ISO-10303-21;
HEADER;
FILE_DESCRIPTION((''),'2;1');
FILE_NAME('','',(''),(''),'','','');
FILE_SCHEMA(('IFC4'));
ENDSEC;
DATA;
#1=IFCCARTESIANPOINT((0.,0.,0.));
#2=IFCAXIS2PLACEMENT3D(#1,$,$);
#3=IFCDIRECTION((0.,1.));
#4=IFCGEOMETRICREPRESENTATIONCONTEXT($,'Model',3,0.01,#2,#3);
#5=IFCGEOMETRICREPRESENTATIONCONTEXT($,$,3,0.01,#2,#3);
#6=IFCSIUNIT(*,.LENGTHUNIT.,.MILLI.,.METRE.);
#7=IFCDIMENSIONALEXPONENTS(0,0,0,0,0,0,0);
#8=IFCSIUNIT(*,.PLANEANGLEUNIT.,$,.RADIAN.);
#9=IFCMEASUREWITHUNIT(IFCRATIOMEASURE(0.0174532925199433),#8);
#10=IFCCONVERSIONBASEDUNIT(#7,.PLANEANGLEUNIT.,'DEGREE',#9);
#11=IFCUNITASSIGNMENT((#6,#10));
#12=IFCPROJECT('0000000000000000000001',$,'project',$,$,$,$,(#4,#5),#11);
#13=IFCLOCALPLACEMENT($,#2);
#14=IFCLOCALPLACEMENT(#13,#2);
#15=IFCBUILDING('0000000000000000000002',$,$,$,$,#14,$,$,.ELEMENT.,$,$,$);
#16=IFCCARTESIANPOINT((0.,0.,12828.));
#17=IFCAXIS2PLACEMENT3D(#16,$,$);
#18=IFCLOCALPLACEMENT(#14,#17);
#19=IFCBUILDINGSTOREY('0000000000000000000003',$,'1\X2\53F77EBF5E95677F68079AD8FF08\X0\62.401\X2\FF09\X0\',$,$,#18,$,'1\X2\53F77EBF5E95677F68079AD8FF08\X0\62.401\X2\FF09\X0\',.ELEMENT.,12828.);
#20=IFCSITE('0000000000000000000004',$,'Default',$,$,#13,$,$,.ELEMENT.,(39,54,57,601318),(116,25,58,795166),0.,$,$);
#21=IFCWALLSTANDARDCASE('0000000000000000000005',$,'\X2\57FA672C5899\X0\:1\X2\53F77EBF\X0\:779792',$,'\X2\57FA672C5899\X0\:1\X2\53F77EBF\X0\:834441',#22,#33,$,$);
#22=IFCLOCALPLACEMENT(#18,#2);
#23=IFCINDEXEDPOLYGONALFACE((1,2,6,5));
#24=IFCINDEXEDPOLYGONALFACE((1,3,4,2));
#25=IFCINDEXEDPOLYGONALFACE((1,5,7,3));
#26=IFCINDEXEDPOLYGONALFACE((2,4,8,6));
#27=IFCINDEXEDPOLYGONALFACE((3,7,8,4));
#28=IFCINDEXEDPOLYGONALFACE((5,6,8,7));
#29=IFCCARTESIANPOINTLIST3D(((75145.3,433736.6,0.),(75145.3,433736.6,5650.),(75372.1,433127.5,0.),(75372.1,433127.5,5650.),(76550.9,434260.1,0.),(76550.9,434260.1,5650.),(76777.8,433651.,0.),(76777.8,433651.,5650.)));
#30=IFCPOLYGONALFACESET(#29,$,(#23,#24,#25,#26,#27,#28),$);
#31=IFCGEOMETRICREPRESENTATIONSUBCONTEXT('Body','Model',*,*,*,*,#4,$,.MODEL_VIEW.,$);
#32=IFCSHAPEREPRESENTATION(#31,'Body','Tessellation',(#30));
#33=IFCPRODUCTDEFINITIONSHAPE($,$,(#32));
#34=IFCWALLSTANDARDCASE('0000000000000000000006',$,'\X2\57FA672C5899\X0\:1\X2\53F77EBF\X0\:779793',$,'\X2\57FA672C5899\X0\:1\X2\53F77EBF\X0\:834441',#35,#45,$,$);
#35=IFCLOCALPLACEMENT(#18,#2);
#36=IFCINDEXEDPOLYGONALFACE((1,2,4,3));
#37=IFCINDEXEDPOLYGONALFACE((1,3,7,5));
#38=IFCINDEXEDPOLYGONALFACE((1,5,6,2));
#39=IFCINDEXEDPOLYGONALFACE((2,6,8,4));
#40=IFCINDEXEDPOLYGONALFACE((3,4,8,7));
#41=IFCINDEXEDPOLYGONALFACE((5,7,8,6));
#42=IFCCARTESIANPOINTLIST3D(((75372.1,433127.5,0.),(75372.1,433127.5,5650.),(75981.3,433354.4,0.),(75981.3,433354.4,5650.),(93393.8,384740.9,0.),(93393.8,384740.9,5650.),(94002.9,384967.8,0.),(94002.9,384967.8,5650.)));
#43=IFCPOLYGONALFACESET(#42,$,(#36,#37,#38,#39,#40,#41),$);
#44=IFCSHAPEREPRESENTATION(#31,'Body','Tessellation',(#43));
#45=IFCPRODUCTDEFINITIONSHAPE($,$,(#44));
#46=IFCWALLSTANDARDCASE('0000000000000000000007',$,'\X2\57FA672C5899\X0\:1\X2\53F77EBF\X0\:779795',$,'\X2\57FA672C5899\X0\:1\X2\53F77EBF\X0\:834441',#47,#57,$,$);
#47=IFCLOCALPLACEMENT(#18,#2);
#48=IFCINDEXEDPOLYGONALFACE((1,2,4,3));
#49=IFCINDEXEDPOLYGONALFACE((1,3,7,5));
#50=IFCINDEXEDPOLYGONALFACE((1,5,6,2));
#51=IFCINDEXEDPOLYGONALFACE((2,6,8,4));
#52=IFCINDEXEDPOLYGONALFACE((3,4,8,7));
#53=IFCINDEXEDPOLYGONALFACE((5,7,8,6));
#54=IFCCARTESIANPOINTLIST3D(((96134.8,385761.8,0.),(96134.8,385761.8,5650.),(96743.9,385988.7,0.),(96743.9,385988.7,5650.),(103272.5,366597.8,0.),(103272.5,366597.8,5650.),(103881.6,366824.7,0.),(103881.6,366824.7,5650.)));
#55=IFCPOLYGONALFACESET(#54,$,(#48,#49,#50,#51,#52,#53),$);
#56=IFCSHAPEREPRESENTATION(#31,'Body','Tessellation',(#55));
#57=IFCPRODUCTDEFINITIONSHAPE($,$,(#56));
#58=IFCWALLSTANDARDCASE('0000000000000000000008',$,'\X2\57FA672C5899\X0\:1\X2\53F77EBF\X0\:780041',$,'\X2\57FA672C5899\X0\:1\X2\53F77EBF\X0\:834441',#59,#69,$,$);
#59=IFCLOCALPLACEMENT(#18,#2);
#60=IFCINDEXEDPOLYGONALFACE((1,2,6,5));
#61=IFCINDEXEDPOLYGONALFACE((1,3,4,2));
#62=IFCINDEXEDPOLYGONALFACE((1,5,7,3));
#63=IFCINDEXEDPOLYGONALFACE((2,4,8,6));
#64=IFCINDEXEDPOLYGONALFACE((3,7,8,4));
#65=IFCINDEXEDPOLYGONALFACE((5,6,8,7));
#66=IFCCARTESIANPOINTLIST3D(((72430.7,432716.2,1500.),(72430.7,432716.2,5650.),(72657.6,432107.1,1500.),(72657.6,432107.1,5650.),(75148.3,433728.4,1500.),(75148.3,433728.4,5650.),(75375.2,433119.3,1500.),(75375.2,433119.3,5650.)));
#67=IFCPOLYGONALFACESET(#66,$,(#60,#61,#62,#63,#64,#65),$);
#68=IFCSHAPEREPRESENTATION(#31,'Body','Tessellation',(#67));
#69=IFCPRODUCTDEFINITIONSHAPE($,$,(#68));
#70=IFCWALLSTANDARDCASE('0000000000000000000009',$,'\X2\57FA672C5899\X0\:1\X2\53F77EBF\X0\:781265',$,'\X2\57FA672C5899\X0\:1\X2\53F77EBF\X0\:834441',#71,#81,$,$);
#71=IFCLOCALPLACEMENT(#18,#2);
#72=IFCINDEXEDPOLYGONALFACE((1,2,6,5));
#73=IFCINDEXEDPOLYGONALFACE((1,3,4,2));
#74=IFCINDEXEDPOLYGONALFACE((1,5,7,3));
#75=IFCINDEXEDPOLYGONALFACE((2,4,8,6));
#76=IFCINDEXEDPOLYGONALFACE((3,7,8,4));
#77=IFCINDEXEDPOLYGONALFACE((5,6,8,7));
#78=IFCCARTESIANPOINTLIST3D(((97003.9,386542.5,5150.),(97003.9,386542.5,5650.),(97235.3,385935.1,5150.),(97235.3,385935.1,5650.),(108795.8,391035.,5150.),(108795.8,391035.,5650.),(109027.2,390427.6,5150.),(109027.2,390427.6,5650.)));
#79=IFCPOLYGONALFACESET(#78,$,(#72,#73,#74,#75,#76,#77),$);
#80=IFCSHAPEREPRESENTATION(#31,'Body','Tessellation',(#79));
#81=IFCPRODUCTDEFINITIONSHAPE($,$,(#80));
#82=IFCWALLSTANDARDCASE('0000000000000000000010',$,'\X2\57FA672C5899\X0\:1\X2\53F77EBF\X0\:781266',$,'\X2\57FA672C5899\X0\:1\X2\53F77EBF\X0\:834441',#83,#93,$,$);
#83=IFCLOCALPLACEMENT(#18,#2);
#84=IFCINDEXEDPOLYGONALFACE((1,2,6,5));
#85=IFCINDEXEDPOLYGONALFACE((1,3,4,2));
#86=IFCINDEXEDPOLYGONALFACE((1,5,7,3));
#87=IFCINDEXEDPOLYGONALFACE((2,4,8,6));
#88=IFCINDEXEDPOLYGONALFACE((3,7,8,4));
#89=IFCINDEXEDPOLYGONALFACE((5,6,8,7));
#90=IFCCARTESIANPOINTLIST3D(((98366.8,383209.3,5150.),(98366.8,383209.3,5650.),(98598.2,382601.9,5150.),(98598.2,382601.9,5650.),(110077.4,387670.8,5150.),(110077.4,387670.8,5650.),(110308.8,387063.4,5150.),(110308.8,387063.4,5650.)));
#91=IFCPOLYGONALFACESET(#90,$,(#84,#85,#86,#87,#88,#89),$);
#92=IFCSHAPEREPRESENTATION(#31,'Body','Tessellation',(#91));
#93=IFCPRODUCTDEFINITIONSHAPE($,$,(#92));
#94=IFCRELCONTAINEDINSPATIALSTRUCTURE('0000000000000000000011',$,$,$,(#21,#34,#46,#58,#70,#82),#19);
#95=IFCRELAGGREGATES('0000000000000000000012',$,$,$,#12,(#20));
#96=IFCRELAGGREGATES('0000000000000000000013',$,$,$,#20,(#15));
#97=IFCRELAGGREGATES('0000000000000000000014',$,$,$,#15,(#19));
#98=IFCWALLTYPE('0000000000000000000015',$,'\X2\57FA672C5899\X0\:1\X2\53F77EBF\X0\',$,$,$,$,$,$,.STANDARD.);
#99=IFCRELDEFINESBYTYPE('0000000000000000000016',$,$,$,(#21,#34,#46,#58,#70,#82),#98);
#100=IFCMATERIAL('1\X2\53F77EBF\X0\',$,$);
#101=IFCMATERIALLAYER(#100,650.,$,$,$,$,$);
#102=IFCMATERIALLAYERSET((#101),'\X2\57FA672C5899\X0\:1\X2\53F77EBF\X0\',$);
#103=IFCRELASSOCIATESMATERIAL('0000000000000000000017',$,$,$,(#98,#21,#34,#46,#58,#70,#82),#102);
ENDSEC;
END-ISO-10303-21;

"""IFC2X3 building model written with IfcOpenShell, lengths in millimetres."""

from ifc_helpers import new_model, entity, si_unit, converted_unit, direction, frame, frame_2d, origin, place, context, subcontext, project, spatial, polyline, rectangle, extrude, clip, bounded_halfspace, material, layer, layer_set, layer_usage, type_object, element, save


model = new_model("IFC2X3")

# Units and contexts
model_context = context("Model", 3, precision=0.01, world=origin(), true_north=direction((0.0, 1.0)))
context_of_model = context(None, 3, precision=0.01, world=origin(), true_north=direction((0.0, 1.0)))
body_context = subcontext(model_context, "Body", "Model", "MODEL_VIEW")
ifc_project = project(units=[si_unit("LENGTHUNIT", "METRE", prefix="MILLI"), converted_unit("PLANEANGLEUNIT", "DEGREE", entity("IfcRatioMeasure", 0.0174532925199433), si_unit("PLANEANGLEUNIT", "RADIAN"), dimensions=[0, 0, 0, 0, 0, 0, 0])], contexts=[model_context, context_of_model])

# Site, building, storey
site_placement = place(None, origin())
site = spatial("IfcSite", under=ifc_project, at=site_placement, Name="Default", CompositionType="ELEMENT", RefLatitude=(39, 54, 57, 601318), RefLongitude=(116, 25, 58, 795166), RefElevation=0.0)
building_placement = place(site_placement, origin())
building = spatial("IfcBuilding", under=site, at=building_placement, CompositionType="ELEMENT")
storey_placement = place(building_placement, frame((0.0, 0.0, 12828.0)))
storey = spatial("IfcBuildingStorey", under=building, at=storey_placement, Name="1号线底板标高（62.401）", LongName="1号线底板标高（62.401）", CompositionType="ELEMENT", Elevation=12828.0)

# Walls
ifc_material_1 = material(Name="1号线")
ifc_layer = layer(ifc_material_1, 650.0)
ifc_layer_set = layer_set([ifc_layer], Name="基本墙:1号线")
ifc_layer_usage_1 = layer_usage(ifc_layer_set, "AXIS2", "NEGATIVE", 325.0)
wall_type = type_object("IfcWallType", Name="基本墙:1号线", PredefinedType="STANDARD", material=ifc_layer_set)
wall_1_placement = place(storey_placement, frame((76664.4, 433955.6, 0.0), z_axis=(0.0, 0.0, 1.0), x_axis=(-0.937112, -0.349028, 0.0)))
element("IfcWallStandardCase", 1, at=wall_1_placement, inside=storey, type_object=wall_type, material=ifc_layer_usage_1, Name="基本墙:1号线:779792", ObjectType="基本墙:1号线:834441", context=body_context, shape_type="Clipping", body=[
    clip(extrude(rectangle(XDim=1500.0, YDim=650.0, at=frame_2d((750.0, 0.0), x_axis=(-1.0, 0.0))), origin(), (0.0, 0.0, 1.0), 5650.0), bounded_halfspace(frame((0.0, -325.0, 5650.0), z_axis=(0.0, 0.0, -1.0), x_axis=(-1.0, 0.0, 0.0)), True, frame((0.0, -325.0, 5650.0)), polyline([(0.0, 0.0), (650.0, 0.0), (1500.0, 0.0), (1500.0, 8.7), (1500.0, 650.0), (850.0, 650.0), (650.0, 650.0), (0.0, 650.0), (0.0, 0.0)]))),
])
ifc_layer_usage_2 = layer_usage(ifc_layer_set, "AXIS2", "NEGATIVE", 325.0)
wall_2_placement = place(storey_placement, frame((75676.7, 433240.9, 0.0), z_axis=(0.0, 0.0, 1.0), x_axis=(0.349028, -0.937112, 0.0)))
element("IfcWallStandardCase", 2, at=wall_2_placement, inside=storey, type_object=wall_type, material=ifc_layer_usage_2, Name="基本墙:1号线:779793", ObjectType="基本墙:1号线:834441", context=body_context, shape_type="Clipping", body=[
    clip(extrude(rectangle(XDim=51633.7, YDim=650.0, at=frame_2d((25816.9, 0.0), x_axis=(-1.0, 0.0))), origin(), (0.0, 0.0, 1.0), 5650.0), bounded_halfspace(frame((0.0, -325.0, 5650.0), z_axis=(0.0, 0.0, -1.0), x_axis=(0.0, 1.0, 0.0)), True, frame((0.0, -325.0, 5650.0)), polyline([(0.0, 0.0), (8.7, 0.0), (50986.2, 0.0), (50984.3, 650.0), (50875.9, 650.0), (208.7, 650.0), (0.0, 650.0), (0.0, 0.0)]))),
])
ifc_layer_usage_3 = layer_usage(ifc_layer_set, "AXIS2", "NEGATIVE", 325.0)
wall_3_placement = place(storey_placement, frame((96439.4, 385875.2, 0.0), z_axis=(0.0, 0.0, 1.0), x_axis=(0.349028, -0.937112, 0.0)))
element("IfcWallStandardCase", 3, at=wall_3_placement, inside=storey, type_object=wall_type, material=ifc_layer_usage_3, Name="基本墙:1号线:779795", ObjectType="基本墙:1号线:834441", context=body_context, shape_type="SweptSolid", body=[
    extrude(rectangle(XDim=20450.0, YDim=650.0, at=frame_2d((10225.0, 0.0), x_axis=(-1.0, 0.0))), origin(), (0.0, 0.0, 1.0), 5650.0),
])
ifc_layer_usage_4 = layer_usage(ifc_layer_set, "AXIS2", "NEGATIVE", 325.0)
wall_4_placement = place(storey_placement, frame((72544.1, 432411.7, 1500.0), z_axis=(0.0, 0.0, 1.0), x_axis=(0.937112, 0.349028, 0.0)))
element("IfcWallStandardCase", 4, at=wall_4_placement, inside=storey, type_object=wall_type, material=ifc_layer_usage_4, Name="基本墙:1号线:780041", ObjectType="基本墙:1号线:834441", context=body_context, shape_type="Clipping", body=[
    clip(extrude(rectangle(XDim=2900.0, YDim=650.0, at=frame_2d((1450.0, 0.0), x_axis=(-1.0, 0.0))), origin(), (0.0, 0.0, 1.0), 4150.0), bounded_halfspace(frame((0.0, -325.0, 4150.0), z_axis=(0.0, 0.0, -1.0), x_axis=(1.0, 0.0, 0.0)), True, frame((0.0, -325.0, 4150.0)), polyline([(0.0, 0.0), (2900.0, 0.0), (2900.0, 8.7), (2900.0, 650.0), (0.0, 650.0), (0.0, 0.0)]))),
])
ifc_layer_usage_5 = layer_usage(ifc_layer_set, "AXIS2", "POSITIVE", -325.0)
wall_5_placement = place(storey_placement, frame((108911.5, 390731.3, 5150.0), z_axis=(0.0, 0.0, 1.0), x_axis=(-0.93448, -0.356017, 0.0)))
element("IfcWallStandardCase", 5, at=wall_5_placement, inside=storey, type_object=wall_type, material=ifc_layer_usage_5, Name="基本墙:1号线:781265", ObjectType="基本墙:1号线:834441", context=body_context, shape_type="SweptSolid", body=[
    extrude(rectangle(XDim=12618.6, YDim=650.0, at=frame_2d((6309.3, 0.0), x_axis=(-1.0, 0.0))), origin(), (0.0, 0.0, 1.0), 500.0),
])
ifc_layer_usage_6 = layer_usage(ifc_layer_set, "AXIS2", "POSITIVE", -325.0)
wall_6_placement = place(storey_placement, frame((110193.1, 387367.1, 5150.0), z_axis=(0.0, 0.0, 1.0), x_axis=(-0.93448, -0.356017, 0.0)))
element("IfcWallStandardCase", 6, at=wall_6_placement, inside=storey, type_object=wall_type, material=ifc_layer_usage_6, Name="基本墙:1号线:781266", ObjectType="基本墙:1号线:834441", context=body_context, shape_type="SweptSolid", body=[
    extrude(rectangle(XDim=12531.7, YDim=650.0, at=frame_2d((6265.9, 0.0), x_axis=(-1.0, 0.0))), origin(), (0.0, 0.0, 1.0), 500.0),
])

save(model, "model.ifc")
